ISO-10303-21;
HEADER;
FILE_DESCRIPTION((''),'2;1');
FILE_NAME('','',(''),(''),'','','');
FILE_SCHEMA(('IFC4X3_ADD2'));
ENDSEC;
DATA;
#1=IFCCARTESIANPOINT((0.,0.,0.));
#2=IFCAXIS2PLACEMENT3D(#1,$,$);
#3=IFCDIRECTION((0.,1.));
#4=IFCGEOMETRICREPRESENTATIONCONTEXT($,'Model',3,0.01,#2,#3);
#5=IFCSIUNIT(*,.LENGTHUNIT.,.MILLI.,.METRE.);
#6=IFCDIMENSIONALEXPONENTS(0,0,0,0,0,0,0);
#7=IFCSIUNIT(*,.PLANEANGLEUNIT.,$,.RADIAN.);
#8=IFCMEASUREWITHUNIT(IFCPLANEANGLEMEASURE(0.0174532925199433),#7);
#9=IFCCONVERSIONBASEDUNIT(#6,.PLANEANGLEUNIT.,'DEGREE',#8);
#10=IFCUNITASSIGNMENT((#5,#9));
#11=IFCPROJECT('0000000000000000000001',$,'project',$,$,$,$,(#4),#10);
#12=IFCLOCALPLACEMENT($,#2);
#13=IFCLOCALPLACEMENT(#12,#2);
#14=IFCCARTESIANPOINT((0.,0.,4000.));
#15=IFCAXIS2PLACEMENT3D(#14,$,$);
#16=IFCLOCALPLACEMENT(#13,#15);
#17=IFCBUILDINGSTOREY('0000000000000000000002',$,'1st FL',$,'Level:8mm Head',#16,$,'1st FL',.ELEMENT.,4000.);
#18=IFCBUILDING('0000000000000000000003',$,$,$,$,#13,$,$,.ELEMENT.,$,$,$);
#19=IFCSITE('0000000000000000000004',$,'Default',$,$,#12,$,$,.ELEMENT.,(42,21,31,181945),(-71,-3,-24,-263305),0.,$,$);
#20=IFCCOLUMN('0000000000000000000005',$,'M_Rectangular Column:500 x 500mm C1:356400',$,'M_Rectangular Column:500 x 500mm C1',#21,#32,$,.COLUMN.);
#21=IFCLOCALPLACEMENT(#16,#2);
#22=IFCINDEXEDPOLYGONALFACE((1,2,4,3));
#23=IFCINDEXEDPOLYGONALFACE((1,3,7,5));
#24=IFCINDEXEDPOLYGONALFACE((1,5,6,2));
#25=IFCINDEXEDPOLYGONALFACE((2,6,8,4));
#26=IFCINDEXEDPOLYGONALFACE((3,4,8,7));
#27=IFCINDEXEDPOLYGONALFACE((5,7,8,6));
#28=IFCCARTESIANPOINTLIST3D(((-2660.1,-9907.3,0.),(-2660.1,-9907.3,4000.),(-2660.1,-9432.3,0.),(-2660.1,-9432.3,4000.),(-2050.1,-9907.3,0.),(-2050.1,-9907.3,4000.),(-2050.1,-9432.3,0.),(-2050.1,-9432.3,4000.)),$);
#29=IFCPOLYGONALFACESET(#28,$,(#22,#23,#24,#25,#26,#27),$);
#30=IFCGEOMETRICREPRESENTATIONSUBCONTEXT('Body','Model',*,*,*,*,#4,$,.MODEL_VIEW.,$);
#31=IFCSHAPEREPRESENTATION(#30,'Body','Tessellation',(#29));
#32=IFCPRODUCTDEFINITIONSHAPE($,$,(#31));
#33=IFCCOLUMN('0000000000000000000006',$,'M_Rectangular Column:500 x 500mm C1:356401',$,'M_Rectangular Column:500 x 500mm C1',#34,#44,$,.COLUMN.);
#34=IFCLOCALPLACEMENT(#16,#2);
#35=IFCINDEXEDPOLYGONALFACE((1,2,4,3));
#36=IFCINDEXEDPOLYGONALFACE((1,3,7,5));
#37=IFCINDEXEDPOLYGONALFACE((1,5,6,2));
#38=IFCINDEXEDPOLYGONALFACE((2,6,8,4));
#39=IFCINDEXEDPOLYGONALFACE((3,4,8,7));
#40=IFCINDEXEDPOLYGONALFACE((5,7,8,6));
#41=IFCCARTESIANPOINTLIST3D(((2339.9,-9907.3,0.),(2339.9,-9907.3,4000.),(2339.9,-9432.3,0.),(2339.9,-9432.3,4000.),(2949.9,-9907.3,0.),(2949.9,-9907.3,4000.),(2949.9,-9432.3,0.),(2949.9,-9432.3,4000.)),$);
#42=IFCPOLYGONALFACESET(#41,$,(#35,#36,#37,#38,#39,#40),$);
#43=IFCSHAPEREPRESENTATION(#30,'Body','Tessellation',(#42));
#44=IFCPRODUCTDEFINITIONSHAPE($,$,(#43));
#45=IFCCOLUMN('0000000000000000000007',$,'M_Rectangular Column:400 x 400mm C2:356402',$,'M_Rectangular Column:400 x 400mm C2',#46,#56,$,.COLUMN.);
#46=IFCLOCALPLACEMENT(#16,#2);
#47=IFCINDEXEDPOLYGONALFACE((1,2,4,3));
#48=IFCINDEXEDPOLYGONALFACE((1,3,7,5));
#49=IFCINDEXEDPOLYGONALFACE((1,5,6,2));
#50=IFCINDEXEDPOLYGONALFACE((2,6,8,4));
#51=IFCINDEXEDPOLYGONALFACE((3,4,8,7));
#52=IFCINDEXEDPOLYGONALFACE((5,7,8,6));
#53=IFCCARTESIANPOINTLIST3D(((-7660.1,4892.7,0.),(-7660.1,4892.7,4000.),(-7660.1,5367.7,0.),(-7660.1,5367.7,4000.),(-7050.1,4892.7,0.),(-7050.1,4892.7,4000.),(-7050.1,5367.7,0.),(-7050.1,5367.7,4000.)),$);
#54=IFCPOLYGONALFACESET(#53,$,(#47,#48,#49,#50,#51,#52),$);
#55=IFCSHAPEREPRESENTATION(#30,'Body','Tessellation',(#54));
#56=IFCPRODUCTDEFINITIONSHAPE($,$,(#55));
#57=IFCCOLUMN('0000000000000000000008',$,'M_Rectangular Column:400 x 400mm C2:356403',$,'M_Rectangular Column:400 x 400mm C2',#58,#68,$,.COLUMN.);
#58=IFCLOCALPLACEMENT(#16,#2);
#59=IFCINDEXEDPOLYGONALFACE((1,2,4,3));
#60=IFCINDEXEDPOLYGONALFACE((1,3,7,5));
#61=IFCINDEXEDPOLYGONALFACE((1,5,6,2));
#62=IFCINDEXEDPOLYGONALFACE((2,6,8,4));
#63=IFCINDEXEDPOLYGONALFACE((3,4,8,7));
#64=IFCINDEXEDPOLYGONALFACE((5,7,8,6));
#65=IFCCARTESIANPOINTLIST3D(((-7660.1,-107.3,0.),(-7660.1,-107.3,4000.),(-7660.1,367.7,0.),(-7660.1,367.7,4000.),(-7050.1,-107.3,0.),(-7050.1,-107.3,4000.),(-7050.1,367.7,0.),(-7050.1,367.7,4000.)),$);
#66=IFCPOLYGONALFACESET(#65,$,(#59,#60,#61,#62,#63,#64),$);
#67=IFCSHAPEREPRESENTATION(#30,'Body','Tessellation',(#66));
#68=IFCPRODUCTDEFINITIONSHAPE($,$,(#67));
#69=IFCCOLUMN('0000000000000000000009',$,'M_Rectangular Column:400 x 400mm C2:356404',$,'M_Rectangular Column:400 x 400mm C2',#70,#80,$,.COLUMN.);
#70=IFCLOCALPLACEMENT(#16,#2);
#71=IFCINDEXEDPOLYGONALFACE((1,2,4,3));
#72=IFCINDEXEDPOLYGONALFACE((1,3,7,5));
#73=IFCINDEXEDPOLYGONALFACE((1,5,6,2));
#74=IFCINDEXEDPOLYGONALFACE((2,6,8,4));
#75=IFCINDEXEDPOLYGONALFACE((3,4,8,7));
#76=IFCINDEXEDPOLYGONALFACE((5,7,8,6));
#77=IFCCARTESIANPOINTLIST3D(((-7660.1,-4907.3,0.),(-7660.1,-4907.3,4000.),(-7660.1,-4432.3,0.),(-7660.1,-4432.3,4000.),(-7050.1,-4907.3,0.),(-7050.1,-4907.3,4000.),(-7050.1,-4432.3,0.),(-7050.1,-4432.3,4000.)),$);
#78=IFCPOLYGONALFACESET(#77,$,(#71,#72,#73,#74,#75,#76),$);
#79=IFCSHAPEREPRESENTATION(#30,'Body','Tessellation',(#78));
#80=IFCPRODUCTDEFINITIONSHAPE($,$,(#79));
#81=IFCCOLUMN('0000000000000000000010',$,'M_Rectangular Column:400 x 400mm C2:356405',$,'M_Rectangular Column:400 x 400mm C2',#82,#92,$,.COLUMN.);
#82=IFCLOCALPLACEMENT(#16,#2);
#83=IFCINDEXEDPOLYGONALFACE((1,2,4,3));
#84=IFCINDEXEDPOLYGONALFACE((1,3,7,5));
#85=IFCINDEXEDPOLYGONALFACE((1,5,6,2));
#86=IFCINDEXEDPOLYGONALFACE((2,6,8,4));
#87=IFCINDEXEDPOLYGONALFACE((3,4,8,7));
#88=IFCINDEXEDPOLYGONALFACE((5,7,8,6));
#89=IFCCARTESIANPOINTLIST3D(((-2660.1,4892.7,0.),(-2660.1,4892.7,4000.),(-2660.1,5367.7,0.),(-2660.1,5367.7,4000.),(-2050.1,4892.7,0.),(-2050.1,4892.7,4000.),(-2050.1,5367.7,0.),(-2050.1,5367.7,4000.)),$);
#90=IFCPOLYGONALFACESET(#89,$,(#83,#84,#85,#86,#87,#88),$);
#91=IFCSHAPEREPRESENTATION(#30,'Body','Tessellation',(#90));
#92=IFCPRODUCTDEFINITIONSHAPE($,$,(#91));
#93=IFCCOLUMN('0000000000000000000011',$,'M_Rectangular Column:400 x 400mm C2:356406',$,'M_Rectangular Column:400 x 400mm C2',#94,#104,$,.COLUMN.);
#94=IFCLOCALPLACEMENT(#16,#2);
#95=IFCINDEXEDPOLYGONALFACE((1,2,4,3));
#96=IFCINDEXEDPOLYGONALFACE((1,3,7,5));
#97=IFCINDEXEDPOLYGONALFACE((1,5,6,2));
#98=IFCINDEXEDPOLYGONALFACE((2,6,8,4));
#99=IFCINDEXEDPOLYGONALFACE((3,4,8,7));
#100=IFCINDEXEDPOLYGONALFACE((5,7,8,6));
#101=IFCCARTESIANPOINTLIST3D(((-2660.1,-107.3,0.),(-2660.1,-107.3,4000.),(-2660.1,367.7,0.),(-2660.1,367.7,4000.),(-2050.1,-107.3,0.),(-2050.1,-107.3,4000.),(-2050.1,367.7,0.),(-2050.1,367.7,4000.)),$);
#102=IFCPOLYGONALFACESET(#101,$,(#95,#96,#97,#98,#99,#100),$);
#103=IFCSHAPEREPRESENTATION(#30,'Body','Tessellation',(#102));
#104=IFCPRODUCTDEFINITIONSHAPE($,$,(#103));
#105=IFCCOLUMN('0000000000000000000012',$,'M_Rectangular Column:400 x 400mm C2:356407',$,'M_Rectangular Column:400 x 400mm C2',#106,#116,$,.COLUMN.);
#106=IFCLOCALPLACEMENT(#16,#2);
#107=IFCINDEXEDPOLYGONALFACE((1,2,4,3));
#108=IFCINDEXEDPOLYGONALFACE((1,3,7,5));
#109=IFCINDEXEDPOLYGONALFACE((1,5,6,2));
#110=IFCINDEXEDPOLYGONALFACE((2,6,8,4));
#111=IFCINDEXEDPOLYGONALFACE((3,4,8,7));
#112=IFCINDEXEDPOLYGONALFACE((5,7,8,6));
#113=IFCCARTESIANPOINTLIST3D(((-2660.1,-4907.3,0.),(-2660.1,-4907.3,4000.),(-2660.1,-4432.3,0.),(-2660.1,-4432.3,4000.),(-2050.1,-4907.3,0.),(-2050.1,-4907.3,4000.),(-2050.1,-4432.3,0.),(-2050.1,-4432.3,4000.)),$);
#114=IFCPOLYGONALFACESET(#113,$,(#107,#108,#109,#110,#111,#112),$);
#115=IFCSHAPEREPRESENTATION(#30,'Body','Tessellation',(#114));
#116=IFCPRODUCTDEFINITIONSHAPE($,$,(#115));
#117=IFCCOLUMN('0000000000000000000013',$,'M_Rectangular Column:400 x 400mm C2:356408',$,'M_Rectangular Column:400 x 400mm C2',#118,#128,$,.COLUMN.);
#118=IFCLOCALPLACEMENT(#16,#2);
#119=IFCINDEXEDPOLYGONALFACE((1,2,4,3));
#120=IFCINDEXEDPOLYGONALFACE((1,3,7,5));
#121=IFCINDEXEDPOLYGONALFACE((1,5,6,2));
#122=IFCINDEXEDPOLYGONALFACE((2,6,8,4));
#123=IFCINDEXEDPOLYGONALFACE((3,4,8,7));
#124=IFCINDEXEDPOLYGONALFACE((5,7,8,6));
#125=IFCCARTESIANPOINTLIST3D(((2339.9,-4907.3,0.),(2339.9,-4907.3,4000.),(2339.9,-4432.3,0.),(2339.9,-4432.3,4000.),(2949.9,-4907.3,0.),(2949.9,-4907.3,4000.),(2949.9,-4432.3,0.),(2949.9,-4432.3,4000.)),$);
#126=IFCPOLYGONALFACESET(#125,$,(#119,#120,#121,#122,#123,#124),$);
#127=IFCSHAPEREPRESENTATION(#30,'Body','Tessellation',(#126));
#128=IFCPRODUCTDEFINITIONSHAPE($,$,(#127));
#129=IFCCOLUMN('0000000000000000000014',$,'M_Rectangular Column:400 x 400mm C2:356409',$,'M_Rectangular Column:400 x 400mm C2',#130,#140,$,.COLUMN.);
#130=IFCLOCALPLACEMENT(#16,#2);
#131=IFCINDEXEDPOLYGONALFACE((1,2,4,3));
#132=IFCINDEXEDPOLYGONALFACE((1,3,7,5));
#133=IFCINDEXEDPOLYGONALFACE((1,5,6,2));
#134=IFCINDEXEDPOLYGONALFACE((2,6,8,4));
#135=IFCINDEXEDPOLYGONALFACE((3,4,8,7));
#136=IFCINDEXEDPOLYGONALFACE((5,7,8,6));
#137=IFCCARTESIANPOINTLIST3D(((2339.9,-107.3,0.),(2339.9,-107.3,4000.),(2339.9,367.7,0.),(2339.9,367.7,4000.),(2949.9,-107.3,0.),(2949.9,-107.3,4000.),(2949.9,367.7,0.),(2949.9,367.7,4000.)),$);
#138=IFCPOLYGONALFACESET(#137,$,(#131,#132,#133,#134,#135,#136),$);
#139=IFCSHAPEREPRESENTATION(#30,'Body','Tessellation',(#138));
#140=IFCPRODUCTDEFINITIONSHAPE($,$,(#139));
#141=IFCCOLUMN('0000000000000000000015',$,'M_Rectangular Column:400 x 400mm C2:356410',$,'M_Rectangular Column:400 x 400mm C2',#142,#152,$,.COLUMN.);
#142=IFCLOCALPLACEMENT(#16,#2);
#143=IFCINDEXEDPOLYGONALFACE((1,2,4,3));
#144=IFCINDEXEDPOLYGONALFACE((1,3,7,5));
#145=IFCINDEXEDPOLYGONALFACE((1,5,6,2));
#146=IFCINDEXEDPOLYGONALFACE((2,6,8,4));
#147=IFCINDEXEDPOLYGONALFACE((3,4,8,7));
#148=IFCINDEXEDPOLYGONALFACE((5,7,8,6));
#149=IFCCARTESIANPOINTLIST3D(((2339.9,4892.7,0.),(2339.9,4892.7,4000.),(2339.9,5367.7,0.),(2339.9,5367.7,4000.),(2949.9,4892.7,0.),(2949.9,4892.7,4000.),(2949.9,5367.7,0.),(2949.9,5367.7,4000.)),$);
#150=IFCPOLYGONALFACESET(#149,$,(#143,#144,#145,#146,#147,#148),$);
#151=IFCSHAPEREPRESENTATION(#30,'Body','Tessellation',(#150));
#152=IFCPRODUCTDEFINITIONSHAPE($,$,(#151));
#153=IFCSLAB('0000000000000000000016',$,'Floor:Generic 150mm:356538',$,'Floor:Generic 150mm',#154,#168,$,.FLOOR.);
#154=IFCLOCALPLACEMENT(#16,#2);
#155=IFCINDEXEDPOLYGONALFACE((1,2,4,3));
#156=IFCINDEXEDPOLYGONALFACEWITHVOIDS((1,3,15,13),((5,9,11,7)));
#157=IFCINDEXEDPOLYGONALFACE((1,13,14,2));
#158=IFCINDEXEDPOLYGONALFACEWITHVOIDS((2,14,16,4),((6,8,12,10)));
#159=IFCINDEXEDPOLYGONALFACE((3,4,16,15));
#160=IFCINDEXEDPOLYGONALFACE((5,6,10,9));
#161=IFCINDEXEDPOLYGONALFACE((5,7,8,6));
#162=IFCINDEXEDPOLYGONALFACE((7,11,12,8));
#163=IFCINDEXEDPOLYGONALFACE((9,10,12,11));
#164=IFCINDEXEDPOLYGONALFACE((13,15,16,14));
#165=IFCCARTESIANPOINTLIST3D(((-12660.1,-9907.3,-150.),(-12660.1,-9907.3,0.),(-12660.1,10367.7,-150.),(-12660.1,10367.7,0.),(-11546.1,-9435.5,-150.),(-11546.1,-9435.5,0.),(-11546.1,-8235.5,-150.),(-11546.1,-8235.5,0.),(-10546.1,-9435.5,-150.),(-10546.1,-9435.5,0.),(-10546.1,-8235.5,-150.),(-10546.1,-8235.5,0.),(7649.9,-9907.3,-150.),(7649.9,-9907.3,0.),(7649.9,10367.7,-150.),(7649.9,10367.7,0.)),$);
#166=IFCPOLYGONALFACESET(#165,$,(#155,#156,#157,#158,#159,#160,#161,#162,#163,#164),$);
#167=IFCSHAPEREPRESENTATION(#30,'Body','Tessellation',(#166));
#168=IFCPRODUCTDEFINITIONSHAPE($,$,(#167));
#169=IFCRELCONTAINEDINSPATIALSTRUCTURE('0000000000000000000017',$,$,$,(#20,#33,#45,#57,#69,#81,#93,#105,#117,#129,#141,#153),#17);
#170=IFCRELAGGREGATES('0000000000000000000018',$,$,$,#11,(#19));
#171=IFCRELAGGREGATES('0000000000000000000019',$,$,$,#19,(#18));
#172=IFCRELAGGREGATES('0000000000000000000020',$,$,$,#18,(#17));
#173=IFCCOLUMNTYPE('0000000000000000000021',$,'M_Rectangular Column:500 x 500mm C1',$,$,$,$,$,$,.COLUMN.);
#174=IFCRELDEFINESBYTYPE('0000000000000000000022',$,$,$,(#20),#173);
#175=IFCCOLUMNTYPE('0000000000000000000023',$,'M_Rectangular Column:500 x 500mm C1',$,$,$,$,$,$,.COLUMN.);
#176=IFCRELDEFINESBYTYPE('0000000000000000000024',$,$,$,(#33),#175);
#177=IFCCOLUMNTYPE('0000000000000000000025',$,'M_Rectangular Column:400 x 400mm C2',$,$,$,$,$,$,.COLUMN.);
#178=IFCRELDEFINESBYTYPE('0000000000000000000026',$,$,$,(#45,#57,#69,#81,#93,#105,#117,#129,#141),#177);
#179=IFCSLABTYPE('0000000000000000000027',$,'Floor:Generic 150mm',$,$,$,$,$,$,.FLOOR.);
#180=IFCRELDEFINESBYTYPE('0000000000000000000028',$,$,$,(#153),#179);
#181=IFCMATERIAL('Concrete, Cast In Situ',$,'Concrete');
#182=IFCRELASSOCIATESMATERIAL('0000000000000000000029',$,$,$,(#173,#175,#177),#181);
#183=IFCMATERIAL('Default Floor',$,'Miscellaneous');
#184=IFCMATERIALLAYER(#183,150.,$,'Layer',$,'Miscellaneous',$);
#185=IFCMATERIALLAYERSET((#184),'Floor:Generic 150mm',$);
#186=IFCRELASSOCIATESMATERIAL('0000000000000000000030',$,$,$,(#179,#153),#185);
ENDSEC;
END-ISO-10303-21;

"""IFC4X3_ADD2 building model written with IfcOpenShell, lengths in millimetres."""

from ifc_helpers import new_model, entity, si_unit, converted_unit, direction, frame, frame_2d, origin, origin_2d_with_axis, place, context, subcontext, project, spatial, rectangle, extrude, boolean, source, transform, mapped, material, layer, layer_set, layer_usage, material_profile, profile_set, type_object, type_shapes, element, save


model = new_model("IFC4X3_ADD2")

# Units and contexts
model_context = context("Model", 3, precision=0.01, world=origin(), true_north=direction((0.0, 1.0)))
body_context = subcontext(model_context, "Body", "Model", "MODEL_VIEW")
ifc_project = project(units=[si_unit("LENGTHUNIT", "METRE", prefix="MILLI"), converted_unit("PLANEANGLEUNIT", "DEGREE", entity("IfcPlaneAngleMeasure", 0.0174532925199433), si_unit("PLANEANGLEUNIT", "RADIAN"), dimensions=[0, 0, 0, 0, 0, 0, 0])], contexts=[model_context])

# Site, building, storey
site_placement = place(None, origin())
site = spatial("IfcSite", under=ifc_project, at=site_placement, Name="Default", CompositionType="ELEMENT", RefLatitude=(42, 21, 31, 181945), RefLongitude=(-71, -3, -24, -263305), RefElevation=0.0)
building_placement = place(site_placement, origin())
building = spatial("IfcBuilding", under=site, at=building_placement, CompositionType="ELEMENT")
storey_placement = place(building_placement, frame((0.0, 0.0, 4000.0)))
storey = spatial("IfcBuildingStorey", under=building, at=storey_placement, Name="1st FL", ObjectType="Level:8mm Head", LongName="1st FL", CompositionType="ELEMENT", Elevation=4000.0)

# Columns
ifc_material_1 = material(Name="Concrete, Cast In Situ", Category="Concrete")
ifc_material_profile_1 = material_profile(ifc_material_1, rectangle(XDim=610.0, YDim=475.0, at=frame_2d((0.0, 0.0), x_axis=(1.0, 0.0))), Name="500 x 500mm C1")
ifc_profile_set_1 = profile_set([ifc_material_profile_1], Name="500 x 500mm C1")
column_type_1 = type_object("IfcColumnType", Name="M_Rectangular Column:500 x 500mm C1", PredefinedType="COLUMN", material=ifc_profile_set_1)
shared_shape_1 = source(origin(), body_context, "Body", "SweptSolid", [
    extrude(rectangle(XDim=610.0, YDim=475.0, at=frame_2d((0.0, 0.0), x_axis=(1.0, 0.0))), frame((-2355.1, -9669.8, 4000.0), z_axis=(0.0, 0.0, 1.0), x_axis=(-1.0, 0.0, 0.0)), (0.0, 0.0, 1.0), 4000.0),
])
type_shapes(column_type_1, [shared_shape_1])
column_1_placement = place(storey_placement, frame((0.0, 0.0, -4000.0)))
element("IfcColumn", 1, at=column_1_placement, inside=storey, type_object=column_type_1, Name="M_Rectangular Column:500 x 500mm C1:356400", ObjectType="M_Rectangular Column:500 x 500mm C1", PredefinedType="COLUMN", context=body_context, shape_type="MappedRepresentation", body=[
    mapped(shared_shape_1, transform((0.0, 0.0, 0.0), scale=1.0)),
])
column_type_2 = type_object("IfcColumnType", Name="M_Rectangular Column:500 x 500mm C1", PredefinedType="COLUMN", material=ifc_profile_set_1)
shared_shape_2 = source(origin(), body_context, "Body", "SweptSolid", [
    extrude(rectangle(XDim=610.0, YDim=475.0, at=frame_2d((0.0, 0.0), x_axis=(1.0, 0.0))), frame((2644.9, -9669.8, 4000.0), z_axis=(0.0, 0.0, 1.0), x_axis=(-1.0, 0.0, 0.0)), (0.0, 0.0, 1.0), 4000.0),
])
type_shapes(column_type_2, [shared_shape_2])
column_2_placement = place(storey_placement, frame((0.0, 0.0, -4000.0)))
element("IfcColumn", 2, at=column_2_placement, inside=storey, type_object=column_type_2, Name="M_Rectangular Column:500 x 500mm C1:356401", ObjectType="M_Rectangular Column:500 x 500mm C1", PredefinedType="COLUMN", context=body_context, shape_type="MappedRepresentation", body=[
    mapped(shared_shape_2, transform((0.0, 0.0, 0.0), scale=1.0)),
])
ifc_material_profile_2 = material_profile(ifc_material_1, rectangle(XDim=610.0, YDim=475.0, at=origin_2d_with_axis()), Name="400 x 400mm C2")
ifc_profile_set_2 = profile_set([ifc_material_profile_2], Name="400 x 400mm C2")
column_type_3 = type_object("IfcColumnType", Name="M_Rectangular Column:400 x 400mm C2", PredefinedType="COLUMN", material=ifc_profile_set_2)
shared_shape_3 = source(origin(), body_context, "Body", "SweptSolid", [
    extrude(rectangle(XDim=610.0, YDim=475.0, at=origin_2d_with_axis()), frame((0.0, 0.0, 4000.0), z_axis=(0.0, 0.0, 1.0), x_axis=(-1.0, 0.0, 0.0)), (0.0, 0.0, 1.0), 4000.0),
])
type_shapes(column_type_3, [shared_shape_3])
for number, where, name in (
    (3, (-7355.1, 5130.2, -4000.0), "M_Rectangular Column:400 x 400mm C2:356402"),
    (4, (-7355.1, 130.2, -4000.0), "M_Rectangular Column:400 x 400mm C2:356403"),
    (5, (-7355.1, -4669.8, -4000.0), "M_Rectangular Column:400 x 400mm C2:356404"),
    (6, (-2355.1, 5130.2, -4000.0), "M_Rectangular Column:400 x 400mm C2:356405"),
    (7, (-2355.1, 130.2, -4000.0), "M_Rectangular Column:400 x 400mm C2:356406"),
    (8, (-2355.1, -4669.8, -4000.0), "M_Rectangular Column:400 x 400mm C2:356407"),
    (9, (2644.9, -4669.8, -4000.0), "M_Rectangular Column:400 x 400mm C2:356408"),
    (10, (2644.9, 130.2, -4000.0), "M_Rectangular Column:400 x 400mm C2:356409"),
    (11, (2644.9, 5130.2, -4000.0), "M_Rectangular Column:400 x 400mm C2:356410"),
):
    element("IfcColumn", number, at=place(storey_placement, frame(where)), inside=storey, type_object=column_type_3, Name=name, ObjectType="M_Rectangular Column:400 x 400mm C2", PredefinedType="COLUMN", context=body_context, shape_type="MappedRepresentation", body=[
        mapped(shared_shape_3, transform((0.0, 0.0, 0.0), scale=1.0)),
    ])

# Slab, opening
ifc_material_2 = material(Name="Default Floor", Category="Miscellaneous")
ifc_layer = layer(ifc_material_2, 150.0, Name="Layer", Category="Miscellaneous")
ifc_layer_set = layer_set([ifc_layer], Name="Floor:Generic 150mm")
ifc_layer_usage = layer_usage(ifc_layer_set, "AXIS3", "POSITIVE", 0.0)
slab_type = type_object("IfcSlabType", Name="Floor:Generic 150mm", PredefinedType="FLOOR", material=ifc_layer_set)
slab_placement = place(storey_placement, origin())
slab = element("IfcSlab", 12, at=slab_placement, inside=storey, type_object=slab_type, material=ifc_layer_usage, Name="Floor:Generic 150mm:356538", ObjectType="Floor:Generic 150mm", PredefinedType="FLOOR", context=body_context, shape_type="SweptSolid", body=[
    boolean("DIFFERENCE", extrude(rectangle(XDim=20275.0, YDim=20310.0, at=origin_2d_with_axis()), frame((-2505.1, 230.2, 0.0), z_axis=(0.0, 0.0, -1.0), x_axis=(0.0, 1.0, 0.0)), (0.0, 0.0, 1.0), 150.0), extrude(rectangle(XDim=1200.0, YDim=1000.0, at=frame_2d((0.0, 0.0), x_axis=(1.0, 0.0))), frame((-11046.1, -8835.5, 0.0), z_axis=(0.0, 0.0, -1.0), x_axis=(0.0, -1.0, 0.0)), (0.0, 0.0, 1.0), 150.0)),
])
opening_placement = place(slab_placement, origin())
element("IfcOpeningElement", 13, at=opening_placement, cuts=slab, PredefinedType="OPENING", context=body_context, shape_type="SweptSolid", body=[
    extrude(rectangle(XDim=1200.0, YDim=1000.0, at=frame_2d((0.0, 0.0), x_axis=(1.0, 0.0))), frame((-11046.1, -8835.5, -150.0), z_axis=(0.0, 0.0, 1.0), x_axis=(0.0, 1.0, 0.0)), (0.0, 0.0, 1.0), 150.0),
])

save(model, "model.ifc")
